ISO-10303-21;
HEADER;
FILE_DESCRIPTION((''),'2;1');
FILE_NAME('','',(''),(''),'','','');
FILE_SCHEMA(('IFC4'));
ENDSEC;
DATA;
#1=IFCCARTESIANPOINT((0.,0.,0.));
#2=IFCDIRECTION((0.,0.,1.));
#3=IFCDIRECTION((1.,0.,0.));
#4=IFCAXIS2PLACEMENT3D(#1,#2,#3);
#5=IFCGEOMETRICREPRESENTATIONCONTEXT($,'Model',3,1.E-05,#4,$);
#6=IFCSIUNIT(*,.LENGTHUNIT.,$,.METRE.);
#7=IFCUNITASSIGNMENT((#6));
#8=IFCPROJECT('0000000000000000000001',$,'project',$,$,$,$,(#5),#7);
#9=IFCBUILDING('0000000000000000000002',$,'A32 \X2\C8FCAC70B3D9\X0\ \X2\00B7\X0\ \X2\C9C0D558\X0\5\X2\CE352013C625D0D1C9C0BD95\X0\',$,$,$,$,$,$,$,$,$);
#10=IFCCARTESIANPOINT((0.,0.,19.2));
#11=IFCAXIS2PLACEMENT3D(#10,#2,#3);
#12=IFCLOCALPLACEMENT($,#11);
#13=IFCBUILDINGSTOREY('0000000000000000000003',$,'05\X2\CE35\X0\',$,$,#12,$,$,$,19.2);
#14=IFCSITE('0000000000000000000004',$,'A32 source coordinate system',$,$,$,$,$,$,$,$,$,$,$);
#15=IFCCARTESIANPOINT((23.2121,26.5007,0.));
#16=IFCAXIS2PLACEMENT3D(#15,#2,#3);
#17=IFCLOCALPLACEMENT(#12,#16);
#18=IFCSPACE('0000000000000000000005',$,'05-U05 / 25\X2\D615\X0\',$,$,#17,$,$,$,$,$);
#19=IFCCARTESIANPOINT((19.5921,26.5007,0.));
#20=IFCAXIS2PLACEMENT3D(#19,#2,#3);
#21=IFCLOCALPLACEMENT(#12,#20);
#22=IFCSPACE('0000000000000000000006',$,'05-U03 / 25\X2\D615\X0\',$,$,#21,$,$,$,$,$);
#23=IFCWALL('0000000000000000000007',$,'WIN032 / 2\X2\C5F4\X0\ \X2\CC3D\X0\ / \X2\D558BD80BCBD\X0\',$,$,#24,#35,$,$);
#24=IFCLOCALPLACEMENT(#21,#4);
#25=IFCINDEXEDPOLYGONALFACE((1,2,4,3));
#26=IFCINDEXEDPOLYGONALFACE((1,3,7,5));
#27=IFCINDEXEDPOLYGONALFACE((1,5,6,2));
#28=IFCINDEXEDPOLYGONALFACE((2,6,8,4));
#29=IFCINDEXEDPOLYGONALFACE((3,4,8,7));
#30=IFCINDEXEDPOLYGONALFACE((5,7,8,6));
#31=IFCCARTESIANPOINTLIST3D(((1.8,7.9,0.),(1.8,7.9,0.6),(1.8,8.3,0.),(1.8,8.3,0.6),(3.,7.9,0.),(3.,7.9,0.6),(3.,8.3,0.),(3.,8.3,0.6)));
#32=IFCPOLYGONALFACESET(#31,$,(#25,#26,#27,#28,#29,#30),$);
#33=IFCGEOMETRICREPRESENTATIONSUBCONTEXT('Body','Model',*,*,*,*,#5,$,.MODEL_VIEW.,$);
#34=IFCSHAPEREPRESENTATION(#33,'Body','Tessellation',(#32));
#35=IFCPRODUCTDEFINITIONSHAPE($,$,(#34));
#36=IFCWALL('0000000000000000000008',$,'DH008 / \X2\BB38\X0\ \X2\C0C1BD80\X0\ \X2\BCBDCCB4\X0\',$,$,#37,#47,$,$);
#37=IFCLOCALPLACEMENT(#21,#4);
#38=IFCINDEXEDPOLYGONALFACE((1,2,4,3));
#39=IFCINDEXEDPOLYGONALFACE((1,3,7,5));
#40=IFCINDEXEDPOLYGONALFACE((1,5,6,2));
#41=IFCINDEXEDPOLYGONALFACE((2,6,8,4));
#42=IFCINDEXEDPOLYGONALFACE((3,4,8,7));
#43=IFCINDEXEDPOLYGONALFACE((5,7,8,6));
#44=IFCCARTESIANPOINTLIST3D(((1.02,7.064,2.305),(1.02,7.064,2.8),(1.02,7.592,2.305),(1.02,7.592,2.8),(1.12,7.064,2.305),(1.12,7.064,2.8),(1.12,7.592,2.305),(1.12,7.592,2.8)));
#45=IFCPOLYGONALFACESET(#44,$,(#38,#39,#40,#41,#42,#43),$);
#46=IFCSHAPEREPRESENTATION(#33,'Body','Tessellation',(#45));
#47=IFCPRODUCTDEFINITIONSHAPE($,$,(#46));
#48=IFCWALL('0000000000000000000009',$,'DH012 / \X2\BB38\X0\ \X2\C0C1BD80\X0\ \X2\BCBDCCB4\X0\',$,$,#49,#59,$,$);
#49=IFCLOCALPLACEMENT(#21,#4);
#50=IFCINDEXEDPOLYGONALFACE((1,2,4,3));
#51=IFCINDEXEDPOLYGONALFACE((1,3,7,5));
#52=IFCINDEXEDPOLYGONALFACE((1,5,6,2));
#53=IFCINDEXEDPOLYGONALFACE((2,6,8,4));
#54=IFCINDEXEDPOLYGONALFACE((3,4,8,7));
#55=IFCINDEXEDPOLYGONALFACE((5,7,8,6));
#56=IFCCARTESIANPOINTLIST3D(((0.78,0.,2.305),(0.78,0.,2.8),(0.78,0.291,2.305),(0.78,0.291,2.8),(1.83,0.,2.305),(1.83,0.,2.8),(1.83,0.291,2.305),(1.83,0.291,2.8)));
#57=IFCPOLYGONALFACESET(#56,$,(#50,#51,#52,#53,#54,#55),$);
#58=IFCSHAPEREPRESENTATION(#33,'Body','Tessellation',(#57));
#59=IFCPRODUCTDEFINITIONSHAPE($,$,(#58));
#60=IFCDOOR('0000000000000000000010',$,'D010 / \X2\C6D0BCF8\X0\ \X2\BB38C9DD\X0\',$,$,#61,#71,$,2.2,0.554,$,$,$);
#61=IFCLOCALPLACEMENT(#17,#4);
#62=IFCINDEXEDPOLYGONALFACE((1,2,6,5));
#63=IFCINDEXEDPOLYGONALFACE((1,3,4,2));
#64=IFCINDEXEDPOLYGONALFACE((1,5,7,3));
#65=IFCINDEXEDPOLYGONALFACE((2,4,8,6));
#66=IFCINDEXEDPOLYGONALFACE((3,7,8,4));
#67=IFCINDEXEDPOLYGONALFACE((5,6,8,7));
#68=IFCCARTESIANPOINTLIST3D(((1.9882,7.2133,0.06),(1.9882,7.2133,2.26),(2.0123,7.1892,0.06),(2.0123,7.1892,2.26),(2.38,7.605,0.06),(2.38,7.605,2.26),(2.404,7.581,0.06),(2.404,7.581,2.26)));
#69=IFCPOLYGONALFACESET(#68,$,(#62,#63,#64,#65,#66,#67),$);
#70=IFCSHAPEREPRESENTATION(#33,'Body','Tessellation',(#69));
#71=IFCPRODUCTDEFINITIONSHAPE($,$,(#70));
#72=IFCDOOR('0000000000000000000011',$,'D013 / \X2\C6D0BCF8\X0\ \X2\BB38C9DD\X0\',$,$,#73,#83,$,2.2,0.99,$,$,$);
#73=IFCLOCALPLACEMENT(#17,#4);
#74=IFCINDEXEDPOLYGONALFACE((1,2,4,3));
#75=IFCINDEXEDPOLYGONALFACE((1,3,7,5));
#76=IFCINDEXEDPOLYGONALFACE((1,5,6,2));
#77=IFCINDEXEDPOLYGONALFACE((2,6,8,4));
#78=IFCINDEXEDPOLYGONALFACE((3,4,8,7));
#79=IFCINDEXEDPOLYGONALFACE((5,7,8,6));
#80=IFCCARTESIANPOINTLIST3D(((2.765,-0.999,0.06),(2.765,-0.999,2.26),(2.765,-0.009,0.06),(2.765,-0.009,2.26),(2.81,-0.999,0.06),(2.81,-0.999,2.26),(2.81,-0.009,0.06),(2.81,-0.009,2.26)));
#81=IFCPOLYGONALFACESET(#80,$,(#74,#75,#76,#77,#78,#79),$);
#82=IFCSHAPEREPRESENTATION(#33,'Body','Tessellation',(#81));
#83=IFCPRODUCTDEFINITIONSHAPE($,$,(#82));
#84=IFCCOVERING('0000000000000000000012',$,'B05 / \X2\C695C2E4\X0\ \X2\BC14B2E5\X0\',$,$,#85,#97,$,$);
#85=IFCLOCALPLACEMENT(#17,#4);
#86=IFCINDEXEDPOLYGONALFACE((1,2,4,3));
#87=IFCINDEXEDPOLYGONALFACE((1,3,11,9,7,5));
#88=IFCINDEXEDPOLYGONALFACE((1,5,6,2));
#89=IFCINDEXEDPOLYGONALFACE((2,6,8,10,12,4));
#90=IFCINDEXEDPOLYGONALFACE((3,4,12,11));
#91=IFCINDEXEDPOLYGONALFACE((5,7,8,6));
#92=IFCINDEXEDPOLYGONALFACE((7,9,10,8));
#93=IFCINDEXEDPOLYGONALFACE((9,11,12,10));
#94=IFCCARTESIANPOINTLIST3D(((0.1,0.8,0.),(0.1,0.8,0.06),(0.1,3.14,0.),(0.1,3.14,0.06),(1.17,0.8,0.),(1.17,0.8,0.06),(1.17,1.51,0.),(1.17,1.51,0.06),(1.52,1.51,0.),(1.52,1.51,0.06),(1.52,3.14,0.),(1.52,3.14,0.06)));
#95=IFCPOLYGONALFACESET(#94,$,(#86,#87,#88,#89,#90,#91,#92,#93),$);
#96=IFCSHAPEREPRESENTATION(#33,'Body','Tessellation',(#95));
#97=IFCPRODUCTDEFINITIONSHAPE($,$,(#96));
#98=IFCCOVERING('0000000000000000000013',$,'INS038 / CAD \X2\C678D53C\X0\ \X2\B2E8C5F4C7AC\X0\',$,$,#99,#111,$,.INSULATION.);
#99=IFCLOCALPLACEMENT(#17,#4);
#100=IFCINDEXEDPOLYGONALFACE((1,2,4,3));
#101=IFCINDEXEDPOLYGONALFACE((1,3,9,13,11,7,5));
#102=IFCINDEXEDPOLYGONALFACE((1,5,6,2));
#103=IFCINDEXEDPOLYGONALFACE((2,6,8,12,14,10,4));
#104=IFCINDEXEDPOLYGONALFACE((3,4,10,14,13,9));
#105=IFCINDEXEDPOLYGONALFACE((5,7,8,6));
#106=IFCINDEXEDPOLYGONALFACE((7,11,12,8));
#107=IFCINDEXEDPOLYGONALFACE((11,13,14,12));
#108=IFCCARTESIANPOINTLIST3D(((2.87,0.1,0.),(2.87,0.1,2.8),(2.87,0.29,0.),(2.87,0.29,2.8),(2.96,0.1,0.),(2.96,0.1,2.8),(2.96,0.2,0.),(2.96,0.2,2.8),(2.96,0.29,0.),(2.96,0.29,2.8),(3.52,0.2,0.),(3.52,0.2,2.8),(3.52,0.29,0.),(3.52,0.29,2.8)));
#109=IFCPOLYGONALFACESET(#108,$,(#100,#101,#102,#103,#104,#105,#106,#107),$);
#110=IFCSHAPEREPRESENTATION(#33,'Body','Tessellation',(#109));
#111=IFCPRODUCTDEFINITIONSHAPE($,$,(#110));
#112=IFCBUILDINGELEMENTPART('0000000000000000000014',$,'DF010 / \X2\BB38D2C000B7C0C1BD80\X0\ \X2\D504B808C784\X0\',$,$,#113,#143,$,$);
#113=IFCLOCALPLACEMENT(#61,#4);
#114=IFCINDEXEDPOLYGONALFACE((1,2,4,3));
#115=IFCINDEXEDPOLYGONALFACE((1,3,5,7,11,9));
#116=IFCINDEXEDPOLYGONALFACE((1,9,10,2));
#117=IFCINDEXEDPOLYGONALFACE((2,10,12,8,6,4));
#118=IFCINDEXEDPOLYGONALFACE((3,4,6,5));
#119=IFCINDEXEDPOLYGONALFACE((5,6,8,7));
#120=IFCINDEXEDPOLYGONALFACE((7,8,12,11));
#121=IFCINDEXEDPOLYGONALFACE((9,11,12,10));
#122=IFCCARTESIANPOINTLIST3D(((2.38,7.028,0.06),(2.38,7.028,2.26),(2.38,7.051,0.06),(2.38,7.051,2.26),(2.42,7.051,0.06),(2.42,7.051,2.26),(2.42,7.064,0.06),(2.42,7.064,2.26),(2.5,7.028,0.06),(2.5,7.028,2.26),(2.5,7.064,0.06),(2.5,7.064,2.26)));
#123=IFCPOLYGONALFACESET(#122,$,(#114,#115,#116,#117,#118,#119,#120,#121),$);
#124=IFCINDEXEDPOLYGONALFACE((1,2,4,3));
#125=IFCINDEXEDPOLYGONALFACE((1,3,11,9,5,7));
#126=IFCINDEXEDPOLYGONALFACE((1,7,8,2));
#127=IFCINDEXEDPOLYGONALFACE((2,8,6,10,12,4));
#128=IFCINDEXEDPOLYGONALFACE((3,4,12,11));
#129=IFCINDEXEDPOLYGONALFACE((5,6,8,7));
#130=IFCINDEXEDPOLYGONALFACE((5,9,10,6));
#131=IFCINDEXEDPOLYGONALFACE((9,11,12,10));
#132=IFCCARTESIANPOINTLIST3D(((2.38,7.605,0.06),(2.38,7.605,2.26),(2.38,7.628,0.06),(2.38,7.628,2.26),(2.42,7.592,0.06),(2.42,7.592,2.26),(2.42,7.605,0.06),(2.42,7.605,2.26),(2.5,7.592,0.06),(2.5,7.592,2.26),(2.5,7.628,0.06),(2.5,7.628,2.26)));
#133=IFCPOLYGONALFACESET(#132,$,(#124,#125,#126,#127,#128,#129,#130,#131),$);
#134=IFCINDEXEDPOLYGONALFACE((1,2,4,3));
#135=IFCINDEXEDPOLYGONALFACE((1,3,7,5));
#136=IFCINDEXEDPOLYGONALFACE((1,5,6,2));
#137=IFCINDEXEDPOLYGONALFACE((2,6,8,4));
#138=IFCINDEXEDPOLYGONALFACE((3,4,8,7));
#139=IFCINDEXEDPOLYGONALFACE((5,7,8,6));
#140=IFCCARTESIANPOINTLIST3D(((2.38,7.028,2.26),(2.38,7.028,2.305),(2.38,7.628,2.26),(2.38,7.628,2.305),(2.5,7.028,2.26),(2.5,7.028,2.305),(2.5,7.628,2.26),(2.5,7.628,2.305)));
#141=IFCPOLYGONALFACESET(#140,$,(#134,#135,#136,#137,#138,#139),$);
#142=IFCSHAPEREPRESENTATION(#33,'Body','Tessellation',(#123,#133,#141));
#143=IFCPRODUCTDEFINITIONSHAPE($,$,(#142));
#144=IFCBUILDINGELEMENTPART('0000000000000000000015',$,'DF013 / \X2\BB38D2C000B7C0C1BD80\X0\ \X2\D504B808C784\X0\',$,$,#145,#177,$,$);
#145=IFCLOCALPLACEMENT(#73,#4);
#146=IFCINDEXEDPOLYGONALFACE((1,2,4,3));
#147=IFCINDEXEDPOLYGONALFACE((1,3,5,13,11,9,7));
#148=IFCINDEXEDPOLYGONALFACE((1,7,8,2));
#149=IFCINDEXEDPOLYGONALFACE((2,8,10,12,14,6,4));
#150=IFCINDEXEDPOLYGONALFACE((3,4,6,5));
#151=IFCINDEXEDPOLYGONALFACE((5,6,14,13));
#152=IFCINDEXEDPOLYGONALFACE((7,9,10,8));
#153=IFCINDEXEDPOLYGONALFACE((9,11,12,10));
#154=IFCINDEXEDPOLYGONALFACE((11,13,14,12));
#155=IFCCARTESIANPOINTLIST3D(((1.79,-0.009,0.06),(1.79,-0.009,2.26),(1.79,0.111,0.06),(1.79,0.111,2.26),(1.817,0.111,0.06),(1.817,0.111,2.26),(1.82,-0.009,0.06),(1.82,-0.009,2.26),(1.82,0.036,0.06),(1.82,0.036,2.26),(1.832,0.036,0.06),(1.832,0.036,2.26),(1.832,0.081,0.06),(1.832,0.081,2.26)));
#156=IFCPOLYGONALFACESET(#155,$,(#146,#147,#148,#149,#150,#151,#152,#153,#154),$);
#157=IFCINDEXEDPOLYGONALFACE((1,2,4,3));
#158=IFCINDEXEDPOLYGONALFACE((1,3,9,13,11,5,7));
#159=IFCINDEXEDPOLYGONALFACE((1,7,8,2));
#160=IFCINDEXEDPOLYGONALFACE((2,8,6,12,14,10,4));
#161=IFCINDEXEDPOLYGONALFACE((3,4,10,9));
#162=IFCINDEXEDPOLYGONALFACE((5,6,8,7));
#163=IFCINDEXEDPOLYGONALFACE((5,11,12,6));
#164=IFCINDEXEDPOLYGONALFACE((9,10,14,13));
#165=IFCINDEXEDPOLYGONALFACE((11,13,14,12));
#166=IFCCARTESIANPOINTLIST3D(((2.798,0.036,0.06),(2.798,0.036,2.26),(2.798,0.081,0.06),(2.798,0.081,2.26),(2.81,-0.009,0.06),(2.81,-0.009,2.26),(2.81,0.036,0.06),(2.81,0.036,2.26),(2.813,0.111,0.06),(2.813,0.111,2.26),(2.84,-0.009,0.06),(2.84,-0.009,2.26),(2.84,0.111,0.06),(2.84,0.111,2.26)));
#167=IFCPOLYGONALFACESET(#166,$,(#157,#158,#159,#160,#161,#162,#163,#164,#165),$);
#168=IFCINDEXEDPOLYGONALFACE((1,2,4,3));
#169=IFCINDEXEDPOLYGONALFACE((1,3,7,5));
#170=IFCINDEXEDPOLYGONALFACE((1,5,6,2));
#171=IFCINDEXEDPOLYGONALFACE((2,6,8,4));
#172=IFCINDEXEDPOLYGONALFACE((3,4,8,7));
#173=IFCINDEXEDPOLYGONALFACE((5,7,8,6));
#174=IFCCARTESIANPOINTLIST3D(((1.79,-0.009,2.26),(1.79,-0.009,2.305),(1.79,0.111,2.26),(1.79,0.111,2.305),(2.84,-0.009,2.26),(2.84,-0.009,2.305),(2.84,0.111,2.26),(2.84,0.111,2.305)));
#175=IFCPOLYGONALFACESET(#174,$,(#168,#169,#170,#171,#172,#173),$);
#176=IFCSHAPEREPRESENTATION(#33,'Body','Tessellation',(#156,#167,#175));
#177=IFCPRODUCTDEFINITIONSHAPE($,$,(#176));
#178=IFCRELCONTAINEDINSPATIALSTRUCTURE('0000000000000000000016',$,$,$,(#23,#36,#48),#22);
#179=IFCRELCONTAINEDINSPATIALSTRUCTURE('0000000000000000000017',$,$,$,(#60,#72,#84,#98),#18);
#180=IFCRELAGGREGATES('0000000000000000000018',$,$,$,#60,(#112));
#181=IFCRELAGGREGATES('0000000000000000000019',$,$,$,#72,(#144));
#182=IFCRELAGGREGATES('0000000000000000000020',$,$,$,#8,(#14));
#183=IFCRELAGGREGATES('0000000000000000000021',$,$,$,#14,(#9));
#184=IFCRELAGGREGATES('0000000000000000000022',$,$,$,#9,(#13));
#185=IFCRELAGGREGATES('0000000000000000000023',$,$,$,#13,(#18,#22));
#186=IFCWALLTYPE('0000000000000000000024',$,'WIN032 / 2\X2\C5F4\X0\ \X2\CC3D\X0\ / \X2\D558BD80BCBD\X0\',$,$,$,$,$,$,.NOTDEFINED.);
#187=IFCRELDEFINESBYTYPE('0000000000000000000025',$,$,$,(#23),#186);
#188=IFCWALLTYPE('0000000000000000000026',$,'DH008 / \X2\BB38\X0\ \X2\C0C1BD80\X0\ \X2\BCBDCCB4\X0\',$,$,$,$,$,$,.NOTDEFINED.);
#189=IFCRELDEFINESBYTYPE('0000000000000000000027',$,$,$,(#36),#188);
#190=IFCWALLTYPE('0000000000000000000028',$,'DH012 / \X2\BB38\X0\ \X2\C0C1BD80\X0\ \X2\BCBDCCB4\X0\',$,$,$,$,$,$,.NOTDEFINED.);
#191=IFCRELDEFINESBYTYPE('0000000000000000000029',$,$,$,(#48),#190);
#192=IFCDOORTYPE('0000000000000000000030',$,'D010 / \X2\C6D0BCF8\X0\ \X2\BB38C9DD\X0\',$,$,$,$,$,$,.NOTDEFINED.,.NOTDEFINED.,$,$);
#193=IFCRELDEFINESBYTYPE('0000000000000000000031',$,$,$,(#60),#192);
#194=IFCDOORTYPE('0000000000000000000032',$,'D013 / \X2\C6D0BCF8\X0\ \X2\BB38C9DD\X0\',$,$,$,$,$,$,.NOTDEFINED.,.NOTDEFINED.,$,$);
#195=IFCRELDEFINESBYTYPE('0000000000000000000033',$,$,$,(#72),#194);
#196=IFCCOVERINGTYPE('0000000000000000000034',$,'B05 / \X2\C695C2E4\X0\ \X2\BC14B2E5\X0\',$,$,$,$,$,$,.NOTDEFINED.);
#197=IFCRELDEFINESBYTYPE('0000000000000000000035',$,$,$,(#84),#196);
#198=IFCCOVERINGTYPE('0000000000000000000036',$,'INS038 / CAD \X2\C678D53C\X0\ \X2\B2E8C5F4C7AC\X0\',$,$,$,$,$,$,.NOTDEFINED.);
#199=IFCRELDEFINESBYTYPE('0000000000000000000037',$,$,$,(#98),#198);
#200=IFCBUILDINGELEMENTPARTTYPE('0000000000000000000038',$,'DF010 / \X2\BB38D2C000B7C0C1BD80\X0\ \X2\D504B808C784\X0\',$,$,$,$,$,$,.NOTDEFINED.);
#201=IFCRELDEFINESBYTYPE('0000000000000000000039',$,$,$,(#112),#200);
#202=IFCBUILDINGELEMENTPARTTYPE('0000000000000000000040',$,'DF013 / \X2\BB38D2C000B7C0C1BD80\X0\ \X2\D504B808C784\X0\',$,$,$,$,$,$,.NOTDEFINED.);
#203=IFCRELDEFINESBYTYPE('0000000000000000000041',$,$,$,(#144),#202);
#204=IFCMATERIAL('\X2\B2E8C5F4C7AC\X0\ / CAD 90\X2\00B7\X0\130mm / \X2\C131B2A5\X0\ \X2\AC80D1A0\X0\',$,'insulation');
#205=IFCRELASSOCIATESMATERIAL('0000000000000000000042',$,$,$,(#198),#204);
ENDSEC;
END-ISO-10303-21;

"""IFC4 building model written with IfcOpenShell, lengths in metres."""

from ifc_helpers import new_model, si_unit, frame, origin, origin_with_axes, place, context, subcontext, project, spatial, polyline, outline, extrude, source, transform, mapped, material, type_object, type_shapes, element, aggregate, save


model = new_model("IFC4")

# Units and contexts
model_context = context("Model", 3, precision=1e-05, world=origin_with_axes())
body_context = subcontext(model_context, "Body", "Model", "MODEL_VIEW")
ifc_project = project(units=[si_unit("LENGTHUNIT", "METRE")], contexts=[model_context])

# Site, building, storey, space
storey_placement = place(None, frame((0.0, 0.0, 19.2), z_axis=(0.0, 0.0, 1.0), x_axis=(1.0, 0.0, 0.0)))
space_1_placement = place(storey_placement, frame((23.2121, 26.5007, 0.0), z_axis=(0.0, 0.0, 1.0), x_axis=(1.0, 0.0, 0.0)))
site = spatial("IfcSite", under=ifc_project, Name="A32 source coordinate system")
building = spatial("IfcBuilding", under=site, Name="A32 주거동 · 지하5층–옥탑지붕")
storey = spatial("IfcBuildingStorey", under=building, at=storey_placement, Name="05층", Elevation=19.2)
space_1 = spatial("IfcSpace", under=storey, at=space_1_placement, Name="05-U05 / 25형")

# Shared definitions
space_2_placement = place(storey_placement, frame((19.5921, 26.5007, 0.0), z_axis=(0.0, 0.0, 1.0), x_axis=(1.0, 0.0, 0.0)))
space_2 = spatial("IfcSpace", under=storey, at=space_2_placement, Name="05-U03 / 25형")

# Walls
wall_type_1 = type_object("IfcWallType", Name="WIN032 / 2열 창 / 하부벽", PredefinedType="NOTDEFINED")
shared_shape_1 = source(origin(), body_context, "Body", "SweptSolid", [
    extrude(outline(polyline([(3.0, 7.9), (1.8, 7.9), (1.8, 8.3), (3.0, 8.3), (3.0, 7.9)])), origin(), (0.0, 0.0, 1.0), 0.6),
])
type_shapes(wall_type_1, [shared_shape_1])
wall_1_placement = place(space_2_placement, origin_with_axes())
element("IfcWall", 1, at=wall_1_placement, inside=space_2, type_object=wall_type_1, Name="WIN032 / 2열 창 / 하부벽", context=body_context, shape_type="MappedRepresentation", body=[
    mapped(shared_shape_1, transform((0.0, 0.0, 0.0), scale=1.0)),
])
wall_type_2 = type_object("IfcWallType", Name="DH008 / 문 상부 벽체", PredefinedType="NOTDEFINED")
shared_shape_2 = source(origin(), body_context, "Body", "SweptSolid", [
    extrude(outline(polyline([(1.12, 7.064), (1.02, 7.064), (1.02, 7.592), (1.12, 7.592), (1.12, 7.064)])), frame((0.0, 0.0, 2.305)), (0.0, 0.0, 1.0), 0.495),
])
type_shapes(wall_type_2, [shared_shape_2])
wall_2_placement = place(space_2_placement, origin_with_axes())
element("IfcWall", 2, at=wall_2_placement, inside=space_2, type_object=wall_type_2, Name="DH008 / 문 상부 벽체", context=body_context, shape_type="MappedRepresentation", body=[
    mapped(shared_shape_2, transform((0.0, 0.0, 0.0), scale=1.0)),
])
wall_type_3 = type_object("IfcWallType", Name="DH012 / 문 상부 벽체", PredefinedType="NOTDEFINED")
shared_shape_3 = source(origin(), body_context, "Body", "SweptSolid", [
    extrude(outline(polyline([(0.78, 0.0), (0.78, 0.291), (1.83, 0.291), (1.83, 0.0), (0.78, 0.0)])), frame((0.0, 0.0, 2.305)), (0.0, 0.0, 1.0), 0.495),
])
type_shapes(wall_type_3, [shared_shape_3])
wall_3_placement = place(space_2_placement, origin_with_axes())
element("IfcWall", 3, at=wall_3_placement, inside=space_2, type_object=wall_type_3, Name="DH012 / 문 상부 벽체", context=body_context, shape_type="MappedRepresentation", body=[
    mapped(shared_shape_3, transform((0.0, 0.0, 0.0), scale=1.0)),
])

# Doors
door_type_1 = type_object("IfcDoorType", Name="D010 / 원본 문짝", OperationType="NOTDEFINED", PredefinedType="NOTDEFINED")
shared_shape_4 = source(origin(), body_context, "Body", "SweptSolid", [
    extrude(outline(polyline([(2.0123, 7.1892), (1.9882, 7.2133), (2.38, 7.605), (2.404, 7.581), (2.0123, 7.1892)])), frame((0.0, 0.0, 0.06)), (0.0, 0.0, 1.0), 2.2),
])
type_shapes(door_type_1, [shared_shape_4])
door_1_placement = place(space_1_placement, origin_with_axes())
door_1 = element("IfcDoor", 4, at=door_1_placement, inside=space_1, type_object=door_type_1, Name="D010 / 원본 문짝", OverallHeight=2.2, OverallWidth=0.554, context=body_context, shape_type="MappedRepresentation", body=[
    mapped(shared_shape_4, transform((0.0, 0.0, 0.0), scale=1.0)),
])
door_type_2 = type_object("IfcDoorType", Name="D013 / 원본 문짝", OperationType="NOTDEFINED", PredefinedType="NOTDEFINED")
shared_shape_5 = source(origin(), body_context, "Body", "SweptSolid", [
    extrude(outline(polyline([(2.81, -0.009), (2.81, -0.999), (2.765, -0.999), (2.765, -0.009), (2.81, -0.009)])), frame((0.0, 0.0, 0.06)), (0.0, 0.0, 1.0), 2.2),
])
type_shapes(door_type_2, [shared_shape_5])
door_2_placement = place(space_1_placement, origin_with_axes())
door_2 = element("IfcDoor", 5, at=door_2_placement, inside=space_1, type_object=door_type_2, Name="D013 / 원본 문짝", OverallHeight=2.2, OverallWidth=0.99, context=body_context, shape_type="MappedRepresentation", body=[
    mapped(shared_shape_5, transform((0.0, 0.0, 0.0), scale=1.0)),
])

# Coverings
covering_type_1 = type_object("IfcCoveringType", Name="B05 / 욕실 바닥", PredefinedType="NOTDEFINED")
shared_shape_6 = source(origin(), body_context, "Body", "SweptSolid", [
    extrude(outline(polyline([(0.1, 3.14), (1.52, 3.14), (1.52, 1.51), (1.17, 1.51), (1.17, 0.8), (0.1, 0.8), (0.1, 3.14)])), origin(), (0.0, 0.0, 1.0), 0.06),
])
type_shapes(covering_type_1, [shared_shape_6])
covering_1_placement = place(space_1_placement, origin_with_axes())
element("IfcCovering", 6, at=covering_1_placement, inside=space_1, type_object=covering_type_1, Name="B05 / 욕실 바닥", context=body_context, shape_type="MappedRepresentation", body=[
    mapped(shared_shape_6, transform((0.0, 0.0, 0.0), scale=1.0)),
])
ifc_material = material(Name="단열재 / CAD 90·130mm / 성능 검토", Category="insulation")
covering_type_2 = type_object("IfcCoveringType", Name="INS038 / CAD 외피 단열재", PredefinedType="NOTDEFINED", material=ifc_material)
shared_shape_7 = source(origin(), body_context, "Body", "SweptSolid", [
    extrude(outline(polyline([(2.96, 0.2), (2.96, 0.1), (2.87, 0.1), (2.87, 0.29), (2.96, 0.29), (3.52, 0.29), (3.52, 0.2), (2.96, 0.2)])), origin(), (0.0, 0.0, 1.0), 2.8),
])
type_shapes(covering_type_2, [shared_shape_7])
covering_2_placement = place(space_1_placement, origin_with_axes())
element("IfcCovering", 7, at=covering_2_placement, inside=space_1, type_object=covering_type_2, Name="INS038 / CAD 외피 단열재", PredefinedType="INSULATION", context=body_context, shape_type="MappedRepresentation", body=[
    mapped(shared_shape_7, transform((0.0, 0.0, 0.0), scale=1.0)),
])

# Building element parts
building_element_part_type_1 = type_object("IfcBuildingElementPartType", Name="DF010 / 문틀·상부 프레임", PredefinedType="NOTDEFINED")
shared_shape_8 = source(origin(), body_context, "Body", "SweptSolid", [
    extrude(outline(polyline([(2.38, 7.028), (2.38, 7.051), (2.42, 7.051), (2.42, 7.064), (2.5, 7.064), (2.5, 7.028), (2.38, 7.028)])), frame((0.0, 0.0, 0.06)), (0.0, 0.0, 1.0), 2.2),
    extrude(outline(polyline([(2.5, 7.592), (2.42, 7.592), (2.42, 7.605), (2.38, 7.605), (2.38, 7.628), (2.5, 7.628), (2.5, 7.592)])), frame((0.0, 0.0, 0.06)), (0.0, 0.0, 1.0), 2.2),
    extrude(outline(polyline([(2.38, 7.028), (2.38, 7.628), (2.5, 7.628), (2.5, 7.028), (2.38, 7.028)])), frame((0.0, 0.0, 2.26)), (0.0, 0.0, 1.0), 0.045),
])
type_shapes(building_element_part_type_1, [shared_shape_8])
building_element_part_1_placement = place(door_1_placement, origin_with_axes())
building_element_part_1 = element("IfcBuildingElementPart", 8, at=building_element_part_1_placement, type_object=building_element_part_type_1, Name="DF010 / 문틀·상부 프레임", context=body_context, shape_type="MappedRepresentation", body=[
    mapped(shared_shape_8, transform((0.0, 0.0, 0.0), scale=1.0)),
])
aggregate(door_1, [building_element_part_1])
building_element_part_type_2 = type_object("IfcBuildingElementPartType", Name="DF013 / 문틀·상부 프레임", PredefinedType="NOTDEFINED")
shared_shape_9 = source(origin(), body_context, "Body", "SweptSolid", [
    extrude(outline(polyline([(1.79, 0.111), (1.817, 0.111), (1.832, 0.081), (1.832, 0.036), (1.82, 0.036), (1.82, -0.009), (1.79, -0.009), (1.79, 0.111)])), frame((0.0, 0.0, 0.06)), (0.0, 0.0, 1.0), 2.2),
    extrude(outline(polyline([(2.81, -0.009), (2.81, 0.036), (2.798, 0.036), (2.798, 0.081), (2.813, 0.111), (2.84, 0.111), (2.84, -0.009), (2.81, -0.009)])), frame((0.0, 0.0, 0.06)), (0.0, 0.0, 1.0), 2.2),
    extrude(outline(polyline([(1.79, -0.009), (1.79, 0.111), (2.84, 0.111), (2.84, -0.009), (1.79, -0.009)])), frame((0.0, 0.0, 2.26)), (0.0, 0.0, 1.0), 0.045),
])
type_shapes(building_element_part_type_2, [shared_shape_9])
building_element_part_2_placement = place(door_2_placement, origin_with_axes())
building_element_part_2 = element("IfcBuildingElementPart", 9, at=building_element_part_2_placement, type_object=building_element_part_type_2, Name="DF013 / 문틀·상부 프레임", context=body_context, shape_type="MappedRepresentation", body=[
    mapped(shared_shape_9, transform((0.0, 0.0, 0.0), scale=1.0)),
])
aggregate(door_2, [building_element_part_2])

save(model, "model.ifc")
